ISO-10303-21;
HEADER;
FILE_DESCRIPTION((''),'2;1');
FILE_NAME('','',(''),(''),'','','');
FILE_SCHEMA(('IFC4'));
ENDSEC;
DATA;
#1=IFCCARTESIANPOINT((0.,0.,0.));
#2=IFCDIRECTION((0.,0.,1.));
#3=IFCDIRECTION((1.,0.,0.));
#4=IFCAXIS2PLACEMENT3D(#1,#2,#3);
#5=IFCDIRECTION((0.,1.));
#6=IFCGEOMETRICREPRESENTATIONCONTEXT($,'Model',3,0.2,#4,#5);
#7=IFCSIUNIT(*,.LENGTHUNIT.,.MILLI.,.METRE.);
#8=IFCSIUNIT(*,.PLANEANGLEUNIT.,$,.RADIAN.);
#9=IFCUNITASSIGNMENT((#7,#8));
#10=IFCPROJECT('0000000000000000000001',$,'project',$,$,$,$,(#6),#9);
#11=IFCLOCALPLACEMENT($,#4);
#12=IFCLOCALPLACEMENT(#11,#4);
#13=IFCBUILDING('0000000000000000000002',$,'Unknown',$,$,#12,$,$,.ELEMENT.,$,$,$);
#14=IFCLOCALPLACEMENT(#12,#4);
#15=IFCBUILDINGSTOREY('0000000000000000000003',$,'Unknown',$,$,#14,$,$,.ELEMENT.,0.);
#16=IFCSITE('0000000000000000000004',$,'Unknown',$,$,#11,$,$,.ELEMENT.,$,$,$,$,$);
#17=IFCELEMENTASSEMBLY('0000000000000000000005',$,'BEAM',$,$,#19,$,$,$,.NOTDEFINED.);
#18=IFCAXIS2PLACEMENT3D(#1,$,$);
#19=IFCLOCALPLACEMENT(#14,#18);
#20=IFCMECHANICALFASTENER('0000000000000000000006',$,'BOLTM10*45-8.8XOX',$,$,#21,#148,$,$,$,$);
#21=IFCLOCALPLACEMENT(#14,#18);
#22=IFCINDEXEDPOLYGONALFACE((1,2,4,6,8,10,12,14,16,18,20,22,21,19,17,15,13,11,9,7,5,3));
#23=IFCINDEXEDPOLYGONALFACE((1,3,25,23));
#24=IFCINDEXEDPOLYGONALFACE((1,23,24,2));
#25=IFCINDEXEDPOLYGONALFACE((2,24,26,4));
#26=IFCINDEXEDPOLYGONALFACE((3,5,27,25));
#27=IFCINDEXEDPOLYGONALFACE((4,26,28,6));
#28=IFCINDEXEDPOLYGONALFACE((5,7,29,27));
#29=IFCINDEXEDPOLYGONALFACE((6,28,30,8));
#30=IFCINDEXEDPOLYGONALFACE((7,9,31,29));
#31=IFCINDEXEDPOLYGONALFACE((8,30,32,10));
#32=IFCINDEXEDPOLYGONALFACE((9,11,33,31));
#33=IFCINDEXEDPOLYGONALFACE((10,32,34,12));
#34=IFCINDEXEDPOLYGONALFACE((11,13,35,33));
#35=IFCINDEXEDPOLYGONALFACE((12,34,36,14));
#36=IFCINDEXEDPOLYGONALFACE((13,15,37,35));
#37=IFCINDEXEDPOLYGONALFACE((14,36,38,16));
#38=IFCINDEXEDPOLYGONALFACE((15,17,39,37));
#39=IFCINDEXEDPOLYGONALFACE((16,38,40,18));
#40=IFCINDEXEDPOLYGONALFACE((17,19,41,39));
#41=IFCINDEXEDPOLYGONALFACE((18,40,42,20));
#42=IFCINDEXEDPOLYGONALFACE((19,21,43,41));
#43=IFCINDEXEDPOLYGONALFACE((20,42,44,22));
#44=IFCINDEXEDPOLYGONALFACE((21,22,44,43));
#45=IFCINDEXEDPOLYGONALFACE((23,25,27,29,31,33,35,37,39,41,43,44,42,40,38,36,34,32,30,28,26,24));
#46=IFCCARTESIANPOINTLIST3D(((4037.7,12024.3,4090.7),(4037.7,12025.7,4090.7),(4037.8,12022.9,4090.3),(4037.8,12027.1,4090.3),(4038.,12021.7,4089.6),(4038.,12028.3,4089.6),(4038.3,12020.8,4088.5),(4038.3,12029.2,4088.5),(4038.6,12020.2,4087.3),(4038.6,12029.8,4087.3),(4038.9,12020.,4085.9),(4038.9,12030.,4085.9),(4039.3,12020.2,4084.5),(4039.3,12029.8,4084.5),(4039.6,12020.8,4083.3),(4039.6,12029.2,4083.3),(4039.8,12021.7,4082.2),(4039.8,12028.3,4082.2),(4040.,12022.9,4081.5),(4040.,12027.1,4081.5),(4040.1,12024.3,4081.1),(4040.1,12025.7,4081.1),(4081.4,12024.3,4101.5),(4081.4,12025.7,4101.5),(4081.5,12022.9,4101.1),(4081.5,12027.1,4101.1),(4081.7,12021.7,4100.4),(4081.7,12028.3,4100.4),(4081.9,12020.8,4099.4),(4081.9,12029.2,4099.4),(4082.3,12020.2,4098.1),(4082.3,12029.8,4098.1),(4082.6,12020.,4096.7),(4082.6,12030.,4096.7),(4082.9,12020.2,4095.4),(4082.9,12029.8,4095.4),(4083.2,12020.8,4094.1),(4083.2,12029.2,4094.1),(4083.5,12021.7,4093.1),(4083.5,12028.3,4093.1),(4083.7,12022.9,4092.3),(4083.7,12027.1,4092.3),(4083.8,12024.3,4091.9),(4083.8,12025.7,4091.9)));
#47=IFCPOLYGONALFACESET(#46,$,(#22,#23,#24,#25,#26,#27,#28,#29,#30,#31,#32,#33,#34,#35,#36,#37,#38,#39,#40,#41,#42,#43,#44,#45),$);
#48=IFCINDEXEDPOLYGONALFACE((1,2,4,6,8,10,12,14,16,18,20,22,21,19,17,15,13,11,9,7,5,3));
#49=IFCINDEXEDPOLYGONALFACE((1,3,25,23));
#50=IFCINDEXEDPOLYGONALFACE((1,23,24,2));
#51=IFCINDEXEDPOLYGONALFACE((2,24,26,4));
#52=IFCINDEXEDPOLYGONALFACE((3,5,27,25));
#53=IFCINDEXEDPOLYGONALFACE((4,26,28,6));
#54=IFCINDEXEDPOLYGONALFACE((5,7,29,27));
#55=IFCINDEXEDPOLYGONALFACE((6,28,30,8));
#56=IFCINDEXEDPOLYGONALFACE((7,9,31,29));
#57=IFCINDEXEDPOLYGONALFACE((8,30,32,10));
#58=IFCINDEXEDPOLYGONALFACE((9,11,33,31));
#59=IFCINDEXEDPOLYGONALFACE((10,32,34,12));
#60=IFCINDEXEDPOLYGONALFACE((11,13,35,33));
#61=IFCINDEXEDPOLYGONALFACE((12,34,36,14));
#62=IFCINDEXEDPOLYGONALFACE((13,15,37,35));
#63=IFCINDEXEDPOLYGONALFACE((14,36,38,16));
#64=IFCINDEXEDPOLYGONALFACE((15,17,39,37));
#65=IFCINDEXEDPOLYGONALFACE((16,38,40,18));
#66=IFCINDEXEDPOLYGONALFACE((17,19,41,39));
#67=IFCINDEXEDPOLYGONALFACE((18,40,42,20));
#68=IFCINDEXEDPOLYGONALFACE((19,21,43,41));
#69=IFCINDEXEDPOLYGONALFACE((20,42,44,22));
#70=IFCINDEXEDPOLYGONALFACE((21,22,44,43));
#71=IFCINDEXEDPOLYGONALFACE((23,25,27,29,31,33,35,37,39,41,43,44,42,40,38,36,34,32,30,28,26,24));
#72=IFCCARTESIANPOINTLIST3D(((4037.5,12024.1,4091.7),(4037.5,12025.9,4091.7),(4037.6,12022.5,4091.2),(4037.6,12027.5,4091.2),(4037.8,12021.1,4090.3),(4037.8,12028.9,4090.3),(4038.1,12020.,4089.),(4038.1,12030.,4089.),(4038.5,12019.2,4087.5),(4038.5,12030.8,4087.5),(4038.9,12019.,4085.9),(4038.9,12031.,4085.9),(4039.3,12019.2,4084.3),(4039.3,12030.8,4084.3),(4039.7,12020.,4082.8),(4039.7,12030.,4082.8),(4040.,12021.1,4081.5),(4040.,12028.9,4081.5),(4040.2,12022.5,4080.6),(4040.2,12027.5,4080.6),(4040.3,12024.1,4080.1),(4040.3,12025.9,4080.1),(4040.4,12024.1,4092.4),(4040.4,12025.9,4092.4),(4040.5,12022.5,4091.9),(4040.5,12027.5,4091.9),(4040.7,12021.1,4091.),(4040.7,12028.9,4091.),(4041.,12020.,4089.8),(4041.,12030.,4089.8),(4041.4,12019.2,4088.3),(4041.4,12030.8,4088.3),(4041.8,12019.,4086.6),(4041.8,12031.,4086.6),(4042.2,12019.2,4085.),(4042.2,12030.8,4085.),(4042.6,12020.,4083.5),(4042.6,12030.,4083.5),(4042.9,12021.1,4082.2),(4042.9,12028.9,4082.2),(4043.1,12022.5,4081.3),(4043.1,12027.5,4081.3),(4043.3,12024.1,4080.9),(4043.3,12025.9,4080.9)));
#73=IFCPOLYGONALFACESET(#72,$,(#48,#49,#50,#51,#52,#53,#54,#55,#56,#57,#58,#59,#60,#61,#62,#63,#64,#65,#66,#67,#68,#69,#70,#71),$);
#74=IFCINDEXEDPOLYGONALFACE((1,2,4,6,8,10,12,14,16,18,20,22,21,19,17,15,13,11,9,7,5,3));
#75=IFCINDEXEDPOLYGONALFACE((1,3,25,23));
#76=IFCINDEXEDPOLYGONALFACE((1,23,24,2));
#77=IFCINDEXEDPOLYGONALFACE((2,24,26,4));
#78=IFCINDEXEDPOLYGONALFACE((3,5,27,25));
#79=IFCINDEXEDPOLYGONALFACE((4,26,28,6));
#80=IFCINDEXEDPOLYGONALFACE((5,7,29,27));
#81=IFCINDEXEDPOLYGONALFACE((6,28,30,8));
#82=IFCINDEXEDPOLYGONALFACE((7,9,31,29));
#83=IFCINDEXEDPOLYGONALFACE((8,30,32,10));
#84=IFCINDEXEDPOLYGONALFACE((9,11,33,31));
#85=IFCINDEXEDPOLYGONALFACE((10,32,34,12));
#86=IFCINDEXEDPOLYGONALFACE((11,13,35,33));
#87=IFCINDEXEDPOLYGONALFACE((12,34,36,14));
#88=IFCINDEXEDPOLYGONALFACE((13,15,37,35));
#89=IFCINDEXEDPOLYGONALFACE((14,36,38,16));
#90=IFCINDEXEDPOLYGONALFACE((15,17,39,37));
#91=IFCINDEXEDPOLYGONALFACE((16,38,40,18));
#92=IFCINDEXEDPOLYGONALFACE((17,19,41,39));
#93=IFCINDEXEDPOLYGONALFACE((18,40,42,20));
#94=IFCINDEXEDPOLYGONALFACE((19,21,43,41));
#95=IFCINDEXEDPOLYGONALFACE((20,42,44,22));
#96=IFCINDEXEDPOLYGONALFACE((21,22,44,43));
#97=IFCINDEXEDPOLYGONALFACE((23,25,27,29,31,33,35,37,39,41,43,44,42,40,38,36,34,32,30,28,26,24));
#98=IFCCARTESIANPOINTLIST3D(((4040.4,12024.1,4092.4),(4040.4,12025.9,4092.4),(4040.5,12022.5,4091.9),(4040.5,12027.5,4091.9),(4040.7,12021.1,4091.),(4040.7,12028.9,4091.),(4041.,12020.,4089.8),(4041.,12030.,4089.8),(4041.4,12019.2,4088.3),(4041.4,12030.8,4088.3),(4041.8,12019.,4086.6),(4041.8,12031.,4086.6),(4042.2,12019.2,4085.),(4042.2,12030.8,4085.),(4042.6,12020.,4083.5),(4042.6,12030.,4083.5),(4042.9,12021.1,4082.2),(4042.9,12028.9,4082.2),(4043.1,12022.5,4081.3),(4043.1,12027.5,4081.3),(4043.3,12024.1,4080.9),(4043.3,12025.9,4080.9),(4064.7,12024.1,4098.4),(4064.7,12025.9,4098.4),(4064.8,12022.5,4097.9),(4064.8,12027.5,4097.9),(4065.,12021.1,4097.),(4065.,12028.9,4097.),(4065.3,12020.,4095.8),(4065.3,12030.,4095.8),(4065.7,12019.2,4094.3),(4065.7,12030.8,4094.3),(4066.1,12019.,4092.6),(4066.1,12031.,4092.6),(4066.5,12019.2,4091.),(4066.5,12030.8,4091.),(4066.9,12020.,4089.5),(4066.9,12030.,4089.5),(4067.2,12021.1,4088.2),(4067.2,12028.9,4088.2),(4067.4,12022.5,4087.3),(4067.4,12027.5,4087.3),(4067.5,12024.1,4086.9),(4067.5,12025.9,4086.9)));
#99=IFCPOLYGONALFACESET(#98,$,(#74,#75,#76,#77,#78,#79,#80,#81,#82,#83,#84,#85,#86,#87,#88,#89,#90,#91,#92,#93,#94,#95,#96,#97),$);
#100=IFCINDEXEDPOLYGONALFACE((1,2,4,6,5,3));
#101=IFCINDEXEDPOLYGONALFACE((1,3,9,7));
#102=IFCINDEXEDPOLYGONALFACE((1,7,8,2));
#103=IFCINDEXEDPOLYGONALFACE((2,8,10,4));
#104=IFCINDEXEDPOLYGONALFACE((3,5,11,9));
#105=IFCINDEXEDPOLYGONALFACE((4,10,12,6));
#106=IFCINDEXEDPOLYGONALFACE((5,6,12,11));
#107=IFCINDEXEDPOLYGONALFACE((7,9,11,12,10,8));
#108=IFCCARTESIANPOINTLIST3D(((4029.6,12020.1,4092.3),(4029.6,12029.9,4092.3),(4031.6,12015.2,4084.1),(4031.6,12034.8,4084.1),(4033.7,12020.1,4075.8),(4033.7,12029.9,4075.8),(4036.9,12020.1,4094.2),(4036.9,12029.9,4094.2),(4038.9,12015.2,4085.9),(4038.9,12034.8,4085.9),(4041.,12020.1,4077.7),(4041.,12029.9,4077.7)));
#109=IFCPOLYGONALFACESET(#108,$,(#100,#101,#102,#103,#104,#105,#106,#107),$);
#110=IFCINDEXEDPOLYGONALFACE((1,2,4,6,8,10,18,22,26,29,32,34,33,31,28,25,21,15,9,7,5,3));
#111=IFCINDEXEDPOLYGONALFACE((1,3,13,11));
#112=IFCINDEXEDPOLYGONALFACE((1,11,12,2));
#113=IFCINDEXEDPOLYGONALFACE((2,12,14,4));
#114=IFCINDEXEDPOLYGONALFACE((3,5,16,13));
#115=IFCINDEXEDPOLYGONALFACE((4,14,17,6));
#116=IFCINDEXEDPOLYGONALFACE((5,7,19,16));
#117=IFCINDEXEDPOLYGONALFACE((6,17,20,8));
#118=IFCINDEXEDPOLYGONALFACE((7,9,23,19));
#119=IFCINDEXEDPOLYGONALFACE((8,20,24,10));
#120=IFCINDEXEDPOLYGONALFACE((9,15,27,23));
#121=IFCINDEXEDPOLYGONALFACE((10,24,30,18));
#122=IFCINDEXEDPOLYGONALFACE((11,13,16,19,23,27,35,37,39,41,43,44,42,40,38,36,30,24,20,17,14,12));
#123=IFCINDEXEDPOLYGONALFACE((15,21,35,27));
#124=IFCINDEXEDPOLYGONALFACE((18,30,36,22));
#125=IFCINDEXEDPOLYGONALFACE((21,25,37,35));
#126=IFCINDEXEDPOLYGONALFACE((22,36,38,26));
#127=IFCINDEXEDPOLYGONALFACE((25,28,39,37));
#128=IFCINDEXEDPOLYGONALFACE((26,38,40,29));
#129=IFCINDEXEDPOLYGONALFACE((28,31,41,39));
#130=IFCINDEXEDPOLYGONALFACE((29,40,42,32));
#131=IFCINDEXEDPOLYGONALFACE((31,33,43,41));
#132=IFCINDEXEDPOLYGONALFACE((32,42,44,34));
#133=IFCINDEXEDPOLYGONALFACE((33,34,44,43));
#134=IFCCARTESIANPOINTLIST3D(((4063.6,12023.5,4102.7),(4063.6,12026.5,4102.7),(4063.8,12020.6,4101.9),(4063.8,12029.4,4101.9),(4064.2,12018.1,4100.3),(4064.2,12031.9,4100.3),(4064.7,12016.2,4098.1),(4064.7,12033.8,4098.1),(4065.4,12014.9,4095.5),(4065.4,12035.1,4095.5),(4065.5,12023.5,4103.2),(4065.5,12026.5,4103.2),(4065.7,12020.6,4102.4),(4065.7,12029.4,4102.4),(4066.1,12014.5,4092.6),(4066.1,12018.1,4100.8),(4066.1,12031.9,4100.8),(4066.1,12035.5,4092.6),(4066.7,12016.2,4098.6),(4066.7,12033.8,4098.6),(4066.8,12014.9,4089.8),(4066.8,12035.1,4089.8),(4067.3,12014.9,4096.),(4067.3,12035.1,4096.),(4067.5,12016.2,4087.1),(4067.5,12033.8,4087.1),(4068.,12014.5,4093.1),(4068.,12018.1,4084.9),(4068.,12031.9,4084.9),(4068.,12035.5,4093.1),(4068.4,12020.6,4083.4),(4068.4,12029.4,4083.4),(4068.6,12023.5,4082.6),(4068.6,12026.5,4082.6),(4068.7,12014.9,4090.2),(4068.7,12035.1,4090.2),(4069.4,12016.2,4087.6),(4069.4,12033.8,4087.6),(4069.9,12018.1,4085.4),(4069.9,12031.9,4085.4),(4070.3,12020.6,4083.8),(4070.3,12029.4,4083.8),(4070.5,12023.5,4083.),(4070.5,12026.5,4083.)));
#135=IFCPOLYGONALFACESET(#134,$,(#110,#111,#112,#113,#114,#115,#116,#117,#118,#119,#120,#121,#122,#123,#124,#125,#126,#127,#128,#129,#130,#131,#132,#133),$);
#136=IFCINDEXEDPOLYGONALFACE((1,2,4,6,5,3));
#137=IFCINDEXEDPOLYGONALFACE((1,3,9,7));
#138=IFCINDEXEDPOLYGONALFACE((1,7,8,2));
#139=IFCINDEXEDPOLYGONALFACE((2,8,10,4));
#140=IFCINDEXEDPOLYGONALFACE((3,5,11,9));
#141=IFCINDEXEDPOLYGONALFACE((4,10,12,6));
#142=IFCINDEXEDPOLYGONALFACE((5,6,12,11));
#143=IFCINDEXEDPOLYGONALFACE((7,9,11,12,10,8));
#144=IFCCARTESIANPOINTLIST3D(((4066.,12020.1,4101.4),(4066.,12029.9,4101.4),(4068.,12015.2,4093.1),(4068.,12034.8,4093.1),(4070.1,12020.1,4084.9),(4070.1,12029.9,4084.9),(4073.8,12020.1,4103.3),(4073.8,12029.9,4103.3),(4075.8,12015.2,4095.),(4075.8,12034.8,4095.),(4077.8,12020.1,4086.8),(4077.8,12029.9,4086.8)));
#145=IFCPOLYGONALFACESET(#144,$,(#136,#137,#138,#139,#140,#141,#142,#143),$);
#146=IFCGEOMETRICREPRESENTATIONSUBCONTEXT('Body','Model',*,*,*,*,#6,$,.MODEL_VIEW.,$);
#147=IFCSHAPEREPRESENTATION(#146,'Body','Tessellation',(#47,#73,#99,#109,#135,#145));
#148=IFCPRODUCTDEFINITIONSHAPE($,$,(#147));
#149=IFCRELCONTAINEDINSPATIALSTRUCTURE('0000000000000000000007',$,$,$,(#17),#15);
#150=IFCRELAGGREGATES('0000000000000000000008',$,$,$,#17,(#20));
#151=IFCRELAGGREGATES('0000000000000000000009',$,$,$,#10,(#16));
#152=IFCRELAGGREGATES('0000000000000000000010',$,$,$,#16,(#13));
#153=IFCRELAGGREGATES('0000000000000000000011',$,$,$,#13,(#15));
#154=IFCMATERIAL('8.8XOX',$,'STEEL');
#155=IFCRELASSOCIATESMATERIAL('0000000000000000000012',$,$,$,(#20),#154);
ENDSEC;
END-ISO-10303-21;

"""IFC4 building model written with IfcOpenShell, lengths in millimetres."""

from ifc_helpers import new_model, si_unit, direction, frame, origin_with_axes, place, context, subcontext, project, spatial, line, arc, indexed_curve, outline, extrude, source, transform, mapped, material, element, aggregate, save


model = new_model("IFC4")

# Units and contexts
model_context = context("Model", 3, precision=0.2, world=origin_with_axes(), true_north=direction((0.0, 1.0)))
body_context = subcontext(model_context, "Body", "Model", "MODEL_VIEW")
ifc_project = project(units=[si_unit("LENGTHUNIT", "METRE", prefix="MILLI"), si_unit("PLANEANGLEUNIT", "RADIAN")], contexts=[model_context])

# Site, building, storey
site_placement = place(None, origin_with_axes())
site = spatial("IfcSite", under=ifc_project, at=site_placement, Name="Unknown", CompositionType="ELEMENT")
building_placement = place(site_placement, origin_with_axes())
building = spatial("IfcBuilding", under=site, at=building_placement, Name="Unknown", CompositionType="ELEMENT")
storey_placement = place(building_placement, origin_with_axes())
storey = spatial("IfcBuildingStorey", under=building, at=storey_placement, Name="Unknown", CompositionType="ELEMENT", Elevation=0.0)

# Shared definitions
ifc_material_1 = material(Name="8.8XOX", Category="STEEL")

# Element assembly, mechanical fastener
shared_shape_1 = source(origin_with_axes(), body_context, "Body", "SweptSolid", [
    extrude(outline(indexed_curve([(5.0, 0.0), (0.0, 5.0), (-5.0, 0.0), (0.0, -5.0)], segments=[arc(1, 2, 3), arc(3, 4, 1)])), frame((0.0, 0.0, 3.8), z_axis=(0.0, 0.0, -1.0), x_axis=(0.0, 1.0, 0.0)), (0.0, 0.0, 1.0), 45.0),
    extrude(outline(indexed_curve([(6.0, 0.0), (0.0, 6.0), (-6.0, 0.0), (0.0, -6.0)], segments=[arc(1, 2, 3), arc(3, 4, 1)])), frame((0.0, 0.0, 3.8), z_axis=(0.0, 0.0, -1.0), x_axis=(0.0, 1.0, 0.0)), (0.0, 0.0, 1.0), 3.0),
    extrude(outline(indexed_curve([(6.0, 0.0), (0.0, 6.0), (-6.0, 0.0), (0.0, -6.0)], segments=[arc(1, 2, 3), arc(3, 4, 1)])), frame((0.0, 0.0, 0.8), z_axis=(0.0, 0.0, -1.0), x_axis=(0.0, 1.0, 0.0)), (0.0, 0.0, 1.0), 25.0),
    extrude(outline(indexed_curve([(9.8, 0.0), (4.9, 8.5), (-4.9, 8.5), (-9.8, 0.0), (-4.9, -8.5), (4.9, -8.5)], segments=[line(1, 2, 3, 4, 5, 6, 1)])), frame((0.0, 0.0, 11.2), z_axis=(0.0, 0.0, -1.0), x_axis=(0.0, 1.0, 0.0)), (0.0, 0.0, 1.0), 7.5),
    extrude(outline(indexed_curve([(10.5, 0.0), (0.0, 10.5), (-10.5, 0.0), (0.0, -10.5)], segments=[arc(1, 2, 3), arc(3, 4, 1)])), frame((0.0, 0.0, -24.2), z_axis=(0.0, 0.0, -1.0), x_axis=(0.0, 1.0, 0.0)), (0.0, 0.0, 1.0), 2.0),
    extrude(outline(indexed_curve([(9.8, 0.0), (4.9, 8.5), (-4.9, 8.5), (-9.8, 0.0), (-4.9, -8.5), (4.9, -8.5)], segments=[line(1, 2, 3, 4, 5, 6, 1)])), frame((0.0, 0.0, -26.2), z_axis=(0.0, 0.0, -1.0), x_axis=(0.0, 1.0, 0.0)), (0.0, 0.0, 1.0), 8.0),
])
assembly_1_placement = place(storey_placement, frame((4052.8, 12000.0, 4094.5), z_axis=(0.970613, 0.0, 0.240648), x_axis=(0.0, 1.0, 0.0)))
assembly_1 = element("IfcElementAssembly", 1, at=assembly_1_placement, inside=storey, Name="BEAM", PredefinedType="NOTDEFINED")
mechanical_fastener_1_placement = place(assembly_1_placement, frame((25.0, -5.0, -11.8), z_axis=(0.0, 0.0, -1.0), x_axis=(0.0, 1.0, 0.0)))
mechanical_fastener_1 = element("IfcMechanicalFastener", 2, at=mechanical_fastener_1_placement, material=ifc_material_1, Name="BOLTM10*45-8.8XOX", context=body_context, shape_type="MappedRepresentation", body=[
    mapped(shared_shape_1, transform((0.0, 0.0, 0.0))),
])
aggregate(assembly_1, [mechanical_fastener_1])

save(model, "model.ifc")
